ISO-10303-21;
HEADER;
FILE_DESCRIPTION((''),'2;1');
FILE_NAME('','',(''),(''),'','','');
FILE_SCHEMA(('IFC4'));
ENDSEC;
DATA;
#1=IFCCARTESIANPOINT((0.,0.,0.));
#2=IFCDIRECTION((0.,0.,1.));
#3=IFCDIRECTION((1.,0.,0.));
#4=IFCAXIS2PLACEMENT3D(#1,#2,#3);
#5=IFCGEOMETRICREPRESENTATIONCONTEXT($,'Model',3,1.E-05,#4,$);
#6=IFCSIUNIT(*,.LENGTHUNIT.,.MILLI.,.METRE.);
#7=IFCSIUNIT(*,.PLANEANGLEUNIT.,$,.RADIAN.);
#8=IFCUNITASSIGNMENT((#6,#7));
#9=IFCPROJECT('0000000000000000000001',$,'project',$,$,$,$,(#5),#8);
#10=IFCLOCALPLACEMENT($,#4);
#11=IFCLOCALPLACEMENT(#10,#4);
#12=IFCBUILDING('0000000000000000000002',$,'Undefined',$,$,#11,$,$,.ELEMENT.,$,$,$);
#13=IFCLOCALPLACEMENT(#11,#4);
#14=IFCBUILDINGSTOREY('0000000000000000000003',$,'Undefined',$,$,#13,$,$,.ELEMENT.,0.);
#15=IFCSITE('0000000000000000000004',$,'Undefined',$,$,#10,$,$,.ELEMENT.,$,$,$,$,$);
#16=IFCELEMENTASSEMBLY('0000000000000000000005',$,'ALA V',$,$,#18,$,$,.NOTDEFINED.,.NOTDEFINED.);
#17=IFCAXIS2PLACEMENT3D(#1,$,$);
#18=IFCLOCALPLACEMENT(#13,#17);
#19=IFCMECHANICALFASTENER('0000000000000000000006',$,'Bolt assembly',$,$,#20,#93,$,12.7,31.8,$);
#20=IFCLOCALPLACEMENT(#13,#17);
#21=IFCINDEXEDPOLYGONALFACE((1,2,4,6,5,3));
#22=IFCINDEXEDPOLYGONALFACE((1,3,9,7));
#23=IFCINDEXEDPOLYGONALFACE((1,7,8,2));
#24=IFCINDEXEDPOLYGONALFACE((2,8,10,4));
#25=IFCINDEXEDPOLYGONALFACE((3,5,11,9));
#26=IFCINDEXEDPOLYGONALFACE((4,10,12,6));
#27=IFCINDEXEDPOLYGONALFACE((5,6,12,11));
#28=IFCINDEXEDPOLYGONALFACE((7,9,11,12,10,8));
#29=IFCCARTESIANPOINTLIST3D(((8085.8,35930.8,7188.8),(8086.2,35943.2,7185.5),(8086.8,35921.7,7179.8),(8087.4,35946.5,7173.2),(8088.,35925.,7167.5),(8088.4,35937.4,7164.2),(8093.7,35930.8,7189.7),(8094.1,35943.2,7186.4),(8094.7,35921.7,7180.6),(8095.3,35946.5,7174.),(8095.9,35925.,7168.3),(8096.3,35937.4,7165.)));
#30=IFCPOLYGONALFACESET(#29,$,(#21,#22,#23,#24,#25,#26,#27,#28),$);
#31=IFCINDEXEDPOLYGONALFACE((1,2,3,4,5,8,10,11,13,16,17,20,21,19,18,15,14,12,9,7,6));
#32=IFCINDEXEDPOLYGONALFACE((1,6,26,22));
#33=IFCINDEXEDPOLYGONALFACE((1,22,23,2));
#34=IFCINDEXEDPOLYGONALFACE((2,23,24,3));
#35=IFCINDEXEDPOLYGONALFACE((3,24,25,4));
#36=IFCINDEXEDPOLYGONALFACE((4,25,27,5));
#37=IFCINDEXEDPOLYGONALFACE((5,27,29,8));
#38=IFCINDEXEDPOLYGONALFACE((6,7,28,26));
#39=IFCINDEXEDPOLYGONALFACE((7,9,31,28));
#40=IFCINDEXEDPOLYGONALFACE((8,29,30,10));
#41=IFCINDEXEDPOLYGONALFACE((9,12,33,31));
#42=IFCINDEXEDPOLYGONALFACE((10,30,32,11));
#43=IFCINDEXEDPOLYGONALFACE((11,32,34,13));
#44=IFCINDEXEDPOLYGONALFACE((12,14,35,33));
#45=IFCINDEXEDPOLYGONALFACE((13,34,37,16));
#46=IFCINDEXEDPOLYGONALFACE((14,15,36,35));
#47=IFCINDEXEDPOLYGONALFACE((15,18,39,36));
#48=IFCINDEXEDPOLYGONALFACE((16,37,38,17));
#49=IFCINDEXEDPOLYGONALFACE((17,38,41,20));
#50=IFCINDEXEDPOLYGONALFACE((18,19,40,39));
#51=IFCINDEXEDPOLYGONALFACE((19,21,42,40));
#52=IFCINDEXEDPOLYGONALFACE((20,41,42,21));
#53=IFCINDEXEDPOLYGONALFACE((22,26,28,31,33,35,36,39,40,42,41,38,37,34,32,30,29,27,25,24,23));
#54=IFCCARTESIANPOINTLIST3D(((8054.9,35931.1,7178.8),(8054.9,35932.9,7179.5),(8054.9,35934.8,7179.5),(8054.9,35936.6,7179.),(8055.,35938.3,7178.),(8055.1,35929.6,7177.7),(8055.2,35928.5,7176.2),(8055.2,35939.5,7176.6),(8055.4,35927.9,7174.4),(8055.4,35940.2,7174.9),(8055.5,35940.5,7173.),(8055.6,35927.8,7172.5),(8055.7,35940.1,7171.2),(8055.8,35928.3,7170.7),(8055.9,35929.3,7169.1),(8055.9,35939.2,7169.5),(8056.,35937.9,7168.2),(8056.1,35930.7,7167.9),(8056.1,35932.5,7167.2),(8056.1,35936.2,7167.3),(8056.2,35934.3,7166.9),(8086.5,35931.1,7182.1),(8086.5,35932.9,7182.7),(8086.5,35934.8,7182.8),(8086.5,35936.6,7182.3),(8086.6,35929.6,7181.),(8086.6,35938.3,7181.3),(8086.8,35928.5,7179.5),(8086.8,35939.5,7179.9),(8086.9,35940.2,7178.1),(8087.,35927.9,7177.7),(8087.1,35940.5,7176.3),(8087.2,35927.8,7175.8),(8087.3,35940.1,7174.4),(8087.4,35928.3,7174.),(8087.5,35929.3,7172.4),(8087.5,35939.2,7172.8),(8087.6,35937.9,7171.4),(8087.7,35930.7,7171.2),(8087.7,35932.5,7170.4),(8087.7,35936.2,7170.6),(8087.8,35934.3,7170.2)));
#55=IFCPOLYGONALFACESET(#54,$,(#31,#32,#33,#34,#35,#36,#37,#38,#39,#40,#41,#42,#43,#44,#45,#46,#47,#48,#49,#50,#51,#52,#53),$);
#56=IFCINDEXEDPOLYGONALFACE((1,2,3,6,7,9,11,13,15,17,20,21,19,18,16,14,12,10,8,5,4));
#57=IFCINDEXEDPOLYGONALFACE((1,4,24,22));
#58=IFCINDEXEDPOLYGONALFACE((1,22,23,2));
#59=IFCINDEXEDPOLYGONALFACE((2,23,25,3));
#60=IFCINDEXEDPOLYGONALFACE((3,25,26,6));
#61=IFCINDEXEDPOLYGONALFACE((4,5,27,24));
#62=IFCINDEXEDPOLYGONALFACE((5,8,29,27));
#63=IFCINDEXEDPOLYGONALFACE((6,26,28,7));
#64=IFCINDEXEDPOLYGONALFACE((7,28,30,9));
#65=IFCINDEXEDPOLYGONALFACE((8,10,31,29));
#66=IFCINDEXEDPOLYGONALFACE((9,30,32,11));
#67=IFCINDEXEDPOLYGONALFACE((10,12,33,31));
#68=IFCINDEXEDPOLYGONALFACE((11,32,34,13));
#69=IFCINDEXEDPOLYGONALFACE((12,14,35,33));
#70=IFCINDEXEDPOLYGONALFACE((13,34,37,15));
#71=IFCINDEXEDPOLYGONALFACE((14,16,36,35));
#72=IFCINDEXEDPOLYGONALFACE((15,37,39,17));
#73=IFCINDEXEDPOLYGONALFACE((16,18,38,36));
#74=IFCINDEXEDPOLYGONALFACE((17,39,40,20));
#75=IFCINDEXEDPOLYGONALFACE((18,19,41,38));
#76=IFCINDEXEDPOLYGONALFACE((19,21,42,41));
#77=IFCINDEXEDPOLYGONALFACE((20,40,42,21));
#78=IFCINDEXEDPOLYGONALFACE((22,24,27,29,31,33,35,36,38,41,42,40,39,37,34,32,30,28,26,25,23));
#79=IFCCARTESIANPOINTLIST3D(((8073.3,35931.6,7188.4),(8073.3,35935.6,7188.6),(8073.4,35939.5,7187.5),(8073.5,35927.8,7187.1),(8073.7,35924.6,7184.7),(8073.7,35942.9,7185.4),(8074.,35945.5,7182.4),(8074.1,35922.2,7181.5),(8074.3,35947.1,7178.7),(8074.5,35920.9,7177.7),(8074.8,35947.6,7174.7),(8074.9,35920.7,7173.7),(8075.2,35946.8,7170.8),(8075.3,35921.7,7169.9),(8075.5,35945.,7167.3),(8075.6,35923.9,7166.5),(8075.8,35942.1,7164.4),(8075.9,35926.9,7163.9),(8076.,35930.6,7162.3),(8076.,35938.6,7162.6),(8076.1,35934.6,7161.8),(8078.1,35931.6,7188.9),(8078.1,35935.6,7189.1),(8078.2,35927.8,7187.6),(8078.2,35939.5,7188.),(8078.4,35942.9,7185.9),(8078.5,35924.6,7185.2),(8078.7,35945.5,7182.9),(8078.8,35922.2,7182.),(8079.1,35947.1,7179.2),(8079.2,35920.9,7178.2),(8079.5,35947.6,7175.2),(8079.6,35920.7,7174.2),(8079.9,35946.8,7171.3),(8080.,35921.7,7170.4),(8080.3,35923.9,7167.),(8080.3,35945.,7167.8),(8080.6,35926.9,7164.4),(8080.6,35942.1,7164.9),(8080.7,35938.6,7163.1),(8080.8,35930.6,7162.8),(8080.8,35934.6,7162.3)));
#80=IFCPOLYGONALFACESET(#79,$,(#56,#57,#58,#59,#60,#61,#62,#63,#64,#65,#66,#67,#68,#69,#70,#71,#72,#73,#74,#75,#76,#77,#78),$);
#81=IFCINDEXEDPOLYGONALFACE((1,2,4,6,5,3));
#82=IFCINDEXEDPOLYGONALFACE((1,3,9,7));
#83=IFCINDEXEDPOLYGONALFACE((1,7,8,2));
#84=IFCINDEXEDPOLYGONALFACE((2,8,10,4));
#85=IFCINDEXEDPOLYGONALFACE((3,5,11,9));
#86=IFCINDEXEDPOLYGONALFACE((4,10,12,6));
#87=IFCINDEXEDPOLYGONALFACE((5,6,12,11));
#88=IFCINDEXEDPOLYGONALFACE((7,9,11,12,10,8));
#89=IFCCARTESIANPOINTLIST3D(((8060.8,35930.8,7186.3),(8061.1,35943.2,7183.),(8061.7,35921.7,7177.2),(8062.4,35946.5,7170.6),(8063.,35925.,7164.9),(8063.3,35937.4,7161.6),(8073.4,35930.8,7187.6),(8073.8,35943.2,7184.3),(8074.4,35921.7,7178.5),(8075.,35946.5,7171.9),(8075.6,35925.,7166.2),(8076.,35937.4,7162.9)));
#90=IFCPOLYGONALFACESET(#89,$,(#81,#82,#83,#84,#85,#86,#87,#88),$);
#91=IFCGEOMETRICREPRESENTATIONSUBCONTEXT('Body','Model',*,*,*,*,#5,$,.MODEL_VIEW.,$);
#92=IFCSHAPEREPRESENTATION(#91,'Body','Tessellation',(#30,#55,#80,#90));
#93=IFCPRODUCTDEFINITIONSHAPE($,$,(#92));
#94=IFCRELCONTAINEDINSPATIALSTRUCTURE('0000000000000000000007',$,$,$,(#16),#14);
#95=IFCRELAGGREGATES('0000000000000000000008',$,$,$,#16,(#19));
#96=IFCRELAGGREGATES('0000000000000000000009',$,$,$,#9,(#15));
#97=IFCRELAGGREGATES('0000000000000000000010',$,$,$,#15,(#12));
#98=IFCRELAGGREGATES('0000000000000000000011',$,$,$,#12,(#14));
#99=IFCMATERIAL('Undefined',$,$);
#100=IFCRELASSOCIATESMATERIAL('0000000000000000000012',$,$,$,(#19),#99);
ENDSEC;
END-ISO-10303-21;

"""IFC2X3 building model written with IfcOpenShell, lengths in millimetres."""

from ifc_helpers import new_model, si_unit, frame, origin_with_axes, origin_2d_with_axis, place, context, subcontext, project, spatial, polyline, circle, outline, extrude, source, transform, mapped, material, element, aggregate, save


model = new_model("IFC2X3")

# Units and contexts
model_context = context("Model", 3, precision=1e-05, world=origin_with_axes())
body_context = subcontext(model_context, "Body", "Model", "MODEL_VIEW")
ifc_project = project(units=[si_unit("LENGTHUNIT", "METRE", prefix="MILLI"), si_unit("PLANEANGLEUNIT", "RADIAN")], contexts=[model_context])

# Site, building, storey
site_placement = place(None, origin_with_axes())
site = spatial("IfcSite", under=ifc_project, at=site_placement, Name="Undefined", CompositionType="ELEMENT")
building_placement = place(site_placement, origin_with_axes())
building = spatial("IfcBuilding", under=site, at=building_placement, Name="Undefined", CompositionType="ELEMENT")
storey_placement = place(building_placement, origin_with_axes())
storey = spatial("IfcBuildingStorey", under=building, at=storey_placement, Name="Undefined", CompositionType="ELEMENT", Elevation=0.0)

# Element assembly
assembly_1_placement = place(storey_placement, origin_with_axes())
assembly_1 = element("IfcElementAssembly", 1, at=assembly_1_placement, inside=storey, Name="ALA V", AssemblyPlace="NOTDEFINED", PredefinedType="NOTDEFINED")

# Mechanical fastener
ifc_material_1 = material(Name="Undefined")
shared_shape_1 = source(origin_with_axes(), body_context, "Body", "SweptSolid", [
    extrude(outline(polyline([(11.1, -6.4), (11.1, 6.4), (0.0, 12.8), (-11.1, 6.4), (-11.1, -6.4), (0.0, -12.8), (11.1, -6.4)])), frame((0.0, -11.1, 0.0), z_axis=(0.0, 1.0, 0.0), x_axis=(1.0, 0.0, 0.0)), (0.0, 0.0, 1.0), 7.9),
    extrude(circle(Radius=6.3, at=origin_2d_with_axis()), frame((0.0, -3.2, 0.0), z_axis=(0.0, 1.0, 0.0), x_axis=(1.0, 0.0, 0.0)), (0.0, 0.0, 1.0), 31.8),
    extrude(circle(Radius=13.5, at=origin_2d_with_axis()), frame((0.0, 4.5, 0.0), z_axis=(0.0, 1.0, 0.0), x_axis=(1.0, 0.0, 0.0)), (0.0, 0.0, 1.0), 4.8),
    extrude(outline(polyline([(11.1, -6.4), (11.1, 6.4), (0.0, 12.8), (-11.1, 6.4), (-11.1, -6.4), (0.0, -12.8), (11.1, -6.4)])), frame((0.0, 9.3, 0.0), z_axis=(0.0, 1.0, 0.0), x_axis=(1.0, 0.0, 0.0)), (0.0, 0.0, 1.0), 12.7),
])
mechanical_fastener_1_placement = place(assembly_1_placement, frame((8083.9, 35934.1, 7176.2), z_axis=(0.072522, -0.707107, -0.703378), x_axis=(-0.072522, -0.707107, 0.703378)))
mechanical_fastener_1 = element("IfcMechanicalFastener", 2, at=mechanical_fastener_1_placement, material=ifc_material_1, Name="Bolt assembly", NominalDiameter=12.7, NominalLength=31.8, context=body_context, shape_type="MappedRepresentation", body=[
    mapped(shared_shape_1, transform((0.0, 0.0, 0.0))),
])
aggregate(assembly_1, [mechanical_fastener_1])

save(model, "model.ifc")
